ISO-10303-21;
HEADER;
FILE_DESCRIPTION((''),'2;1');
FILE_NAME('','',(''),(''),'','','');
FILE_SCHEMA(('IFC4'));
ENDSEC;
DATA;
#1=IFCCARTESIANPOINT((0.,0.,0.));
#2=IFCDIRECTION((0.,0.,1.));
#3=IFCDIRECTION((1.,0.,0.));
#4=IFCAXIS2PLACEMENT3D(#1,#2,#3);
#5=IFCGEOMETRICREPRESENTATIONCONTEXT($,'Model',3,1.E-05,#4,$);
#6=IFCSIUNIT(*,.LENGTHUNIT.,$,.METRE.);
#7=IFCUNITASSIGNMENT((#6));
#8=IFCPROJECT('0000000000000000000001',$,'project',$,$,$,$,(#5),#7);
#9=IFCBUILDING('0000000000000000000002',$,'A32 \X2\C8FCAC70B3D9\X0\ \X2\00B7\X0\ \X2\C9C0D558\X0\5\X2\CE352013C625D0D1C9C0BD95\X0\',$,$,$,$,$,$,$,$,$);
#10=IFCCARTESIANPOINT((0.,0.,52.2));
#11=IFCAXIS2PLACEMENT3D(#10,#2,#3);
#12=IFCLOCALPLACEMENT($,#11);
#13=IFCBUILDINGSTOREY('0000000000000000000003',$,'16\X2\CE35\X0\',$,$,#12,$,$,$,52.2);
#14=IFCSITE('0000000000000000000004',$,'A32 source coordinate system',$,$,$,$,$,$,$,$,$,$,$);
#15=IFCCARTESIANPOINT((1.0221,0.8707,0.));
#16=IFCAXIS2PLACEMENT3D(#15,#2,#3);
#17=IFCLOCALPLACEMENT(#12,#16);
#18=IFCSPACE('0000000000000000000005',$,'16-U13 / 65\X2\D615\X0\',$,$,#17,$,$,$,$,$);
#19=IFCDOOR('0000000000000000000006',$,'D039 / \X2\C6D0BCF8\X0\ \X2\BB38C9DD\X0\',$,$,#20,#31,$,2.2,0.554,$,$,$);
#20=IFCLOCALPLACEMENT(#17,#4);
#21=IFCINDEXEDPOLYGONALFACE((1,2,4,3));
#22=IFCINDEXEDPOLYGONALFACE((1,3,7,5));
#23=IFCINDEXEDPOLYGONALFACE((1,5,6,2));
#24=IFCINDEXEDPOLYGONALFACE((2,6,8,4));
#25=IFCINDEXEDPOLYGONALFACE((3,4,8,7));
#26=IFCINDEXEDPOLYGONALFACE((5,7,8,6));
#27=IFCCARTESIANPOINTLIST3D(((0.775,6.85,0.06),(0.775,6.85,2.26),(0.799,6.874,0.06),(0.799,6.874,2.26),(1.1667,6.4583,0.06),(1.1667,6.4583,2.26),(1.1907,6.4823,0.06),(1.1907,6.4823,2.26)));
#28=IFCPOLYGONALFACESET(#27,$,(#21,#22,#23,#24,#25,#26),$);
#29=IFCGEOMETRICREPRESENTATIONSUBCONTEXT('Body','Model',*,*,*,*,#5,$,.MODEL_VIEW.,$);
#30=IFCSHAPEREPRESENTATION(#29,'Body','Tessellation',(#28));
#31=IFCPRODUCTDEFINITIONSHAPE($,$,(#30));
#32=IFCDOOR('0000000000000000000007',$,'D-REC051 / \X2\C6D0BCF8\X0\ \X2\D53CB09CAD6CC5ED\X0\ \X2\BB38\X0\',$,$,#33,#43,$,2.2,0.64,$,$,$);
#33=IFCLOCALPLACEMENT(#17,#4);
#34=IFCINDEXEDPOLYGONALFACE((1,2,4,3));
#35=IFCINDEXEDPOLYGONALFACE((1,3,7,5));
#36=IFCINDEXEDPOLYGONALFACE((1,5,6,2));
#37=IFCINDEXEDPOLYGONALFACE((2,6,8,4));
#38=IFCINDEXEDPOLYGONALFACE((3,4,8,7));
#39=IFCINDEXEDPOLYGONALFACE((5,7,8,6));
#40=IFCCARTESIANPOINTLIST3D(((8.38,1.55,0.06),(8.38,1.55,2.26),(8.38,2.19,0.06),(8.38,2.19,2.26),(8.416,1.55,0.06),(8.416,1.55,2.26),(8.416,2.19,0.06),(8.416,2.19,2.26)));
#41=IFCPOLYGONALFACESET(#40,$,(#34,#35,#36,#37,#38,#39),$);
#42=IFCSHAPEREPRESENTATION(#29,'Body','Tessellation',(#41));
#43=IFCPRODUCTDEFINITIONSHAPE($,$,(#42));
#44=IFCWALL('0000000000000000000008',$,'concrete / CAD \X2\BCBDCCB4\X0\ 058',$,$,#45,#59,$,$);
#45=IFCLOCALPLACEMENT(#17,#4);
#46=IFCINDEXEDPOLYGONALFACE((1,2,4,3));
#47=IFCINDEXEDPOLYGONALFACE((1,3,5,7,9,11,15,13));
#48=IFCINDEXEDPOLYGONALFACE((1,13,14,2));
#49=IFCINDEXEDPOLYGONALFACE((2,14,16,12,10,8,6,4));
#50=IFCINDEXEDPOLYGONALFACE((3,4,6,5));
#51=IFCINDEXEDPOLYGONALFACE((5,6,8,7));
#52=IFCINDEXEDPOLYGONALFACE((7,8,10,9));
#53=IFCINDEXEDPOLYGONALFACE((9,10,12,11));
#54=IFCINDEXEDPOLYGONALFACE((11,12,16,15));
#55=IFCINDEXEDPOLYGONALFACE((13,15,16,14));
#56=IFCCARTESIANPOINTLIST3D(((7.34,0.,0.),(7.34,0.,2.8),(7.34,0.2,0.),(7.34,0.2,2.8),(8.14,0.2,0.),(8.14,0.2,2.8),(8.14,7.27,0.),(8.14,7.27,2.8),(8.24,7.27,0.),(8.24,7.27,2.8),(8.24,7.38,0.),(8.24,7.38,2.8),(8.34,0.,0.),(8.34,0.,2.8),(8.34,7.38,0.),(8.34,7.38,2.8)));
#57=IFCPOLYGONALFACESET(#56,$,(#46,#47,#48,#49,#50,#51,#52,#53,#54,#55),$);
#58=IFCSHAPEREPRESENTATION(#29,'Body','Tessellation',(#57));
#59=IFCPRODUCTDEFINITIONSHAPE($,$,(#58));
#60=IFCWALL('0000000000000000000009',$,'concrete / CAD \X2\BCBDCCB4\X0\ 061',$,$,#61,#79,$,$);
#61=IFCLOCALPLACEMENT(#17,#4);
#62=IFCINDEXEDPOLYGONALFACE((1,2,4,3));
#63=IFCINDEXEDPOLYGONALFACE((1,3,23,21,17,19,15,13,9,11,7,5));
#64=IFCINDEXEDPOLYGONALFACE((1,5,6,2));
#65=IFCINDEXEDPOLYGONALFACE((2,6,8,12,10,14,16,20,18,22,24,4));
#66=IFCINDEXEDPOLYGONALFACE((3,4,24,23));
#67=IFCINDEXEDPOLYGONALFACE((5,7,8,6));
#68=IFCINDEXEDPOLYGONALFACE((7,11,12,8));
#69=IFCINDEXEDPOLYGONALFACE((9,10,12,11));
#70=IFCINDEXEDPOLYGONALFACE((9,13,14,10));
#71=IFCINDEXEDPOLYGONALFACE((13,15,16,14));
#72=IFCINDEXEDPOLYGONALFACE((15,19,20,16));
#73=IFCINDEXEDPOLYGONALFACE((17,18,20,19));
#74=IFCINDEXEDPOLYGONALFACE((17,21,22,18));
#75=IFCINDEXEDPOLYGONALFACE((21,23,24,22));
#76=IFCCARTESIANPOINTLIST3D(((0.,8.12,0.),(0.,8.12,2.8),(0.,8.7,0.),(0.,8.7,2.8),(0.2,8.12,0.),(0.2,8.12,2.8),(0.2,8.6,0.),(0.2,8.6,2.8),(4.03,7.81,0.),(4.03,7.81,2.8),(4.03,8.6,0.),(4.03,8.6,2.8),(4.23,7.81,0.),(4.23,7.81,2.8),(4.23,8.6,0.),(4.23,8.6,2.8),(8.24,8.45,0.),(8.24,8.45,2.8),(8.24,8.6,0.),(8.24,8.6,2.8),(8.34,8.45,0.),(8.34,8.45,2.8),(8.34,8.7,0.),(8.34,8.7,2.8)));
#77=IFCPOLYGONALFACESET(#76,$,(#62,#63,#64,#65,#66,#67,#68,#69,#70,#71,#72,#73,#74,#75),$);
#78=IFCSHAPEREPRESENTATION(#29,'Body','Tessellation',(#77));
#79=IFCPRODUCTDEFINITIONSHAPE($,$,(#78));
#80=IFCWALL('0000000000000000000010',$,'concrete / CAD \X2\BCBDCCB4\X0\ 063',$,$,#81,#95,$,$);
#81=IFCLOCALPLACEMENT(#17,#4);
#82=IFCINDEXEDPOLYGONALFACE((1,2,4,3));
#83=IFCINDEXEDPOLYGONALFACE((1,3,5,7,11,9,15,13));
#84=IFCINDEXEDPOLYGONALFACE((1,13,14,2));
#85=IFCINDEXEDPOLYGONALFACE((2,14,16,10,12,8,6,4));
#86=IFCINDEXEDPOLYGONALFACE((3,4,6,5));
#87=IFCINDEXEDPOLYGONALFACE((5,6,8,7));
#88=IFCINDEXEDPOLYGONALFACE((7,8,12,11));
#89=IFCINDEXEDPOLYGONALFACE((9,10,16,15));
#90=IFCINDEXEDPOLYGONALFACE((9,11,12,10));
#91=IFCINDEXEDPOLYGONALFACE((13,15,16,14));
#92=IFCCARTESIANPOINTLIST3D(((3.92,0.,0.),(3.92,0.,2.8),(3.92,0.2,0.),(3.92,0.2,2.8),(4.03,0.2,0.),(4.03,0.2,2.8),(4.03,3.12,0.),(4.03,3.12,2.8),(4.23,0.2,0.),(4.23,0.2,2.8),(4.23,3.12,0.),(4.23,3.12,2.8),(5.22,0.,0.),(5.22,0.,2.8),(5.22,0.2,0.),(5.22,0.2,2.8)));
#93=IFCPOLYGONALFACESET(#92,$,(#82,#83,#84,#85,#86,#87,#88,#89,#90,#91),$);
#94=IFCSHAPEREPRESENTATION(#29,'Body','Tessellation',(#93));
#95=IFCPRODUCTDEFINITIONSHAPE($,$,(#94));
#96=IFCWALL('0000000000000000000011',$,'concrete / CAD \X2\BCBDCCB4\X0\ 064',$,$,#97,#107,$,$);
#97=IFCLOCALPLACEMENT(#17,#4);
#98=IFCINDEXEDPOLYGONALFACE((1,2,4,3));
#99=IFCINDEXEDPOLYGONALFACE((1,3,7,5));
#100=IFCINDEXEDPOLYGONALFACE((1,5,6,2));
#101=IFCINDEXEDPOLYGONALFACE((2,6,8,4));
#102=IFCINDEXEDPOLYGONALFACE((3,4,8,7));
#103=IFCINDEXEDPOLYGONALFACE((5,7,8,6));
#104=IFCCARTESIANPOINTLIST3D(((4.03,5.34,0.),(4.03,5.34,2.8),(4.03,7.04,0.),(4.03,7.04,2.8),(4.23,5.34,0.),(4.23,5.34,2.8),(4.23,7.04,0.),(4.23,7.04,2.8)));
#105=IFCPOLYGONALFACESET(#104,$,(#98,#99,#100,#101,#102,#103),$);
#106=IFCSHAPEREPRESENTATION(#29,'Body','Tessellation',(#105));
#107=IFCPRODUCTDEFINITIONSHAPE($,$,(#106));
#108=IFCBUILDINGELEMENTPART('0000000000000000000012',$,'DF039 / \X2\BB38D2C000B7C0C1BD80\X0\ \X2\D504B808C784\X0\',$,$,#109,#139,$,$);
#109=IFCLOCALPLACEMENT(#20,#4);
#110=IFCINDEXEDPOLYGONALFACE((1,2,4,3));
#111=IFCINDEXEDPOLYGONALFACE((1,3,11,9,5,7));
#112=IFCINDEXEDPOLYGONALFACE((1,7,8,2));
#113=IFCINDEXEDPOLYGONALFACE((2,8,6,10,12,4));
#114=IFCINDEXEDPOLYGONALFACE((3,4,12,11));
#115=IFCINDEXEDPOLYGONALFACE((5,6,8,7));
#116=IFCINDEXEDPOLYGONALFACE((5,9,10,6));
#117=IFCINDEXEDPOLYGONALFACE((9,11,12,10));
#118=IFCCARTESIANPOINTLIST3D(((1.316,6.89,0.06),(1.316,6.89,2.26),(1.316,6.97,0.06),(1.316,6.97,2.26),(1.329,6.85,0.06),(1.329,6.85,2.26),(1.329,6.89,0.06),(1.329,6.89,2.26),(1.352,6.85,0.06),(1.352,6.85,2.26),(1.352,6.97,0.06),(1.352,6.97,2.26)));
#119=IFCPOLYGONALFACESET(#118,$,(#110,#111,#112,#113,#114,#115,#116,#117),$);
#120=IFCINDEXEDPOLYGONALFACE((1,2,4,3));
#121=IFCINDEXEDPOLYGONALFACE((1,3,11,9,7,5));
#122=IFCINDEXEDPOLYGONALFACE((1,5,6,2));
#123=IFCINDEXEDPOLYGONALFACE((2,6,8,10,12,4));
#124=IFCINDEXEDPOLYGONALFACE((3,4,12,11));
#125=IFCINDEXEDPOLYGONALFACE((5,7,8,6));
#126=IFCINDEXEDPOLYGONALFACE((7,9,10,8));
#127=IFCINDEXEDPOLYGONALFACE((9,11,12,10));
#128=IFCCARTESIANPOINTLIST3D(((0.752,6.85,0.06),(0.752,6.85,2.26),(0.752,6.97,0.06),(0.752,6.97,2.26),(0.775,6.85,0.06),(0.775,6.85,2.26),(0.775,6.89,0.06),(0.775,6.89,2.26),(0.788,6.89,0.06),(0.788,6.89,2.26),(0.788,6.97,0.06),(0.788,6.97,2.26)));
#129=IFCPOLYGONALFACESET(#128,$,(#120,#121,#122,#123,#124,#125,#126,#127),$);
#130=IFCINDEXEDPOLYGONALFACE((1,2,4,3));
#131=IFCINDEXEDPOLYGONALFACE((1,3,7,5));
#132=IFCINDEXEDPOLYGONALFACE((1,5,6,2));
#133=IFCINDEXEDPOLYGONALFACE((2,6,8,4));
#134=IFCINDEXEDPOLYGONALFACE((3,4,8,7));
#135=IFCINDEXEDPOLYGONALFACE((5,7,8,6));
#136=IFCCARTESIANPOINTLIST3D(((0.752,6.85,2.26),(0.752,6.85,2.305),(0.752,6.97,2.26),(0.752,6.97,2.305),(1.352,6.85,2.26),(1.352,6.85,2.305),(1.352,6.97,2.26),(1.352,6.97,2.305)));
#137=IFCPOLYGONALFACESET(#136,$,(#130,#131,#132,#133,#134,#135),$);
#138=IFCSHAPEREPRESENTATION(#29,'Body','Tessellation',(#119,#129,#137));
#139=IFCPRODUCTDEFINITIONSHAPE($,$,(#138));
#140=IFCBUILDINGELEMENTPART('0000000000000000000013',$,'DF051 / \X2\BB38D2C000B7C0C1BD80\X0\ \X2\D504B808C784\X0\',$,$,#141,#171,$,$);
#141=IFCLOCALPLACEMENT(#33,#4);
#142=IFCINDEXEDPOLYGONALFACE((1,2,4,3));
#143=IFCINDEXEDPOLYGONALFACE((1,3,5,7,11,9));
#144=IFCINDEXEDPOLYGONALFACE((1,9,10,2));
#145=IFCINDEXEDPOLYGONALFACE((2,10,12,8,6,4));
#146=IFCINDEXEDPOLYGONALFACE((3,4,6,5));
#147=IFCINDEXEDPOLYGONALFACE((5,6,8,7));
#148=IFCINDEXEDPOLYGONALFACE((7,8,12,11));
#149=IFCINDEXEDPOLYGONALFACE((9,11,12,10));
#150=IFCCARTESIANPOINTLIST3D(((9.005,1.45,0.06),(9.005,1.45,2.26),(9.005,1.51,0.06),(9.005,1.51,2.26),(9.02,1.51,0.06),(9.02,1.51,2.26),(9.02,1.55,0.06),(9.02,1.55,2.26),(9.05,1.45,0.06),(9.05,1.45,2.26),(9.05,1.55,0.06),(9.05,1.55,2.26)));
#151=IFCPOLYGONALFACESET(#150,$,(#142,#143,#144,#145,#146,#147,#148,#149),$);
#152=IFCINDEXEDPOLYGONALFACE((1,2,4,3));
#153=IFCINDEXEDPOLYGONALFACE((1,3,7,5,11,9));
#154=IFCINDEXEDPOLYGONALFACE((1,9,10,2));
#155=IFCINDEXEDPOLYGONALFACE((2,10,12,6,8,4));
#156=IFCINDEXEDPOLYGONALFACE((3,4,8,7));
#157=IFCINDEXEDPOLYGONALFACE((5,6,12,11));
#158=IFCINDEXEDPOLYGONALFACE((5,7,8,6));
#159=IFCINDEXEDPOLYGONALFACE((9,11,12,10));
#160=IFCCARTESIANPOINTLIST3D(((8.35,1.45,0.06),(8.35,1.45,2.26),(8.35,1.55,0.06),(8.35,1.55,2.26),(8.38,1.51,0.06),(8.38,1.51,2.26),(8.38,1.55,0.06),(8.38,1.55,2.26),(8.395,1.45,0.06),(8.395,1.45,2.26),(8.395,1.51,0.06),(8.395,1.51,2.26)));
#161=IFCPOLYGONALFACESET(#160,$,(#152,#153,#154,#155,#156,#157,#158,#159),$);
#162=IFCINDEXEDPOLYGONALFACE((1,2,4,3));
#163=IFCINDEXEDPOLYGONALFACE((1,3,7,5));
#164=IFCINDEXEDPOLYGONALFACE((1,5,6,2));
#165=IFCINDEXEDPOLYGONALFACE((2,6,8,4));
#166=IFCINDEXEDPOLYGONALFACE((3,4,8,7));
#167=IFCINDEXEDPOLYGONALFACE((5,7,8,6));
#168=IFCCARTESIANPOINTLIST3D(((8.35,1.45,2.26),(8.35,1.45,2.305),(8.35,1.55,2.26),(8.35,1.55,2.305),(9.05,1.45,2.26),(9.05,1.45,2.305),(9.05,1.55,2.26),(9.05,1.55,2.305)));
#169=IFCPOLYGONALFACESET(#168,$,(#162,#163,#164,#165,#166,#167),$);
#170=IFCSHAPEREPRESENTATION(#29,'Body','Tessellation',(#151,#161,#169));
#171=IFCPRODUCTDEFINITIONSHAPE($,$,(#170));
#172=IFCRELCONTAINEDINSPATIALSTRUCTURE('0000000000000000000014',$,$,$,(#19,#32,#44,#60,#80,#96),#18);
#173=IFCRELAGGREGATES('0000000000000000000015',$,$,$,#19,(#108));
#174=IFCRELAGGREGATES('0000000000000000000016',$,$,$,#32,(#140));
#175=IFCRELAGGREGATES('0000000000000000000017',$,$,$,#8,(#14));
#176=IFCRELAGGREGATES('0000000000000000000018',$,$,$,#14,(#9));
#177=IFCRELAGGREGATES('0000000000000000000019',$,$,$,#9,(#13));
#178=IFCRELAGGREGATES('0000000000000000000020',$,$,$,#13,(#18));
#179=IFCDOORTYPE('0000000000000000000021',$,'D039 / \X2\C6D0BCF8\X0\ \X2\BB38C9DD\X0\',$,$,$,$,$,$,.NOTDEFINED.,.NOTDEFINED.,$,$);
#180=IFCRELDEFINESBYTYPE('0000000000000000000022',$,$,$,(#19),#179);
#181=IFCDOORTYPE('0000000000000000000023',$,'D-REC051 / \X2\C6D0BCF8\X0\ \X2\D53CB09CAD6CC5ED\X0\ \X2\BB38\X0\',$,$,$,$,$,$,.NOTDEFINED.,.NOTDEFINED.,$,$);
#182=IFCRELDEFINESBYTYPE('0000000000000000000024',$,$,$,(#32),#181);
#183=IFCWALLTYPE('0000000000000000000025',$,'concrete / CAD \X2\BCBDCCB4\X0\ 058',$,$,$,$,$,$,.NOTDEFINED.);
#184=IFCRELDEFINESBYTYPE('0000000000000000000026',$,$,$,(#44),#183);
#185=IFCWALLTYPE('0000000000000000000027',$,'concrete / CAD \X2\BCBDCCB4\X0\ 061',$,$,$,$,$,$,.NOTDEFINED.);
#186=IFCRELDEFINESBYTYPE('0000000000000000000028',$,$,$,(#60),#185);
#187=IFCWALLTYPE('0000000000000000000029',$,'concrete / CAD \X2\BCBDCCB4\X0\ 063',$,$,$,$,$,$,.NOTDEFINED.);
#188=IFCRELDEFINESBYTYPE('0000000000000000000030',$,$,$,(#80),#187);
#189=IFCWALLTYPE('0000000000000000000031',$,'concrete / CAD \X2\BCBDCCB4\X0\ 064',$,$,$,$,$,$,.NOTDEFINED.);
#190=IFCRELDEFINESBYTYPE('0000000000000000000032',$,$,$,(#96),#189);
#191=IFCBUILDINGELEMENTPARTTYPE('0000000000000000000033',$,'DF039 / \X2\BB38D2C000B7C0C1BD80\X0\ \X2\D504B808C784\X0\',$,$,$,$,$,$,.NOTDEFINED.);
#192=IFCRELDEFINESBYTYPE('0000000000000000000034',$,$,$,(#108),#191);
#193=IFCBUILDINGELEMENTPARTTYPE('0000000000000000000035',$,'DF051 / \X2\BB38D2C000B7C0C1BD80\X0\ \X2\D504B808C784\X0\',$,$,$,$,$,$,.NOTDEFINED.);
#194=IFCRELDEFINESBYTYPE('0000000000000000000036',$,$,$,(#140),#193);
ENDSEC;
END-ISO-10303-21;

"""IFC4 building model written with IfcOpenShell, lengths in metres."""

from ifc_helpers import new_model, si_unit, frame, origin, origin_with_axes, place, context, subcontext, project, spatial, polyline, outline, extrude, source, transform, mapped, type_object, type_shapes, element, aggregate, save


model = new_model("IFC4")

# Units and contexts
model_context = context("Model", 3, precision=1e-05, world=origin_with_axes())
body_context = subcontext(model_context, "Body", "Model", "MODEL_VIEW")
ifc_project = project(units=[si_unit("LENGTHUNIT", "METRE")], contexts=[model_context])

# Site, building, storey, space
storey_placement = place(None, frame((0.0, 0.0, 52.2), z_axis=(0.0, 0.0, 1.0), x_axis=(1.0, 0.0, 0.0)))
space_placement = place(storey_placement, frame((1.0221, 0.8707, 0.0), z_axis=(0.0, 0.0, 1.0), x_axis=(1.0, 0.0, 0.0)))
site = spatial("IfcSite", under=ifc_project, Name="A32 source coordinate system")
building = spatial("IfcBuilding", under=site, Name="A32 주거동 · 지하5층–옥탑지붕")
storey = spatial("IfcBuildingStorey", under=building, at=storey_placement, Name="16층", Elevation=52.2)
space = spatial("IfcSpace", under=storey, at=space_placement, Name="16-U13 / 65형")

# Doors
door_type_1 = type_object("IfcDoorType", Name="D039 / 원본 문짝", OperationType="NOTDEFINED", PredefinedType="NOTDEFINED")
shared_shape_1 = source(origin(), body_context, "Body", "SweptSolid", [
    extrude(outline(polyline([(1.1907, 6.4823), (1.1667, 6.4583), (0.775, 6.85), (0.799, 6.874), (1.1907, 6.4823)])), frame((0.0, 0.0, 0.06)), (0.0, 0.0, 1.0), 2.2),
])
type_shapes(door_type_1, [shared_shape_1])
door_1_placement = place(space_placement, origin_with_axes())
door_1 = element("IfcDoor", 1, at=door_1_placement, inside=space, type_object=door_type_1, Name="D039 / 원본 문짝", OverallHeight=2.2, OverallWidth=0.554, context=body_context, shape_type="MappedRepresentation", body=[
    mapped(shared_shape_1, transform((0.0, 0.0, 0.0), scale=1.0)),
])
door_type_2 = type_object("IfcDoorType", Name="D-REC051 / 원본 피난구역 문", OperationType="NOTDEFINED", PredefinedType="NOTDEFINED")
shared_shape_2 = source(origin(), body_context, "Body", "SweptSolid", [
    extrude(outline(polyline([(8.416, 2.19), (8.416, 1.55), (8.38, 1.55), (8.38, 2.19), (8.416, 2.19)])), frame((0.0, 0.0, 0.06)), (0.0, 0.0, 1.0), 2.2),
])
type_shapes(door_type_2, [shared_shape_2])
door_2_placement = place(space_placement, origin_with_axes())
door_2 = element("IfcDoor", 2, at=door_2_placement, inside=space, type_object=door_type_2, Name="D-REC051 / 원본 피난구역 문", OverallHeight=2.2, OverallWidth=0.64, context=body_context, shape_type="MappedRepresentation", body=[
    mapped(shared_shape_2, transform((0.0, 0.0, 0.0), scale=1.0)),
])

# Walls
wall_type_1 = type_object("IfcWallType", Name="concrete / CAD 벽체 058", PredefinedType="NOTDEFINED")
shared_shape_3 = source(origin(), body_context, "Body", "SweptSolid", [
    extrude(outline(polyline([(8.34, 0.0), (7.34, 0.0), (7.34, 0.2), (8.14, 0.2), (8.14, 7.27), (8.24, 7.27), (8.24, 7.38), (8.34, 7.38), (8.34, 0.0)])), origin(), (0.0, 0.0, 1.0), 2.8),
])
type_shapes(wall_type_1, [shared_shape_3])
wall_1_placement = place(space_placement, origin_with_axes())
element("IfcWall", 3, at=wall_1_placement, inside=space, type_object=wall_type_1, Name="concrete / CAD 벽체 058", context=body_context, shape_type="MappedRepresentation", body=[
    mapped(shared_shape_3, transform((0.0, 0.0, 0.0), scale=1.0)),
])
wall_type_2 = type_object("IfcWallType", Name="concrete / CAD 벽체 061", PredefinedType="NOTDEFINED")
shared_shape_4 = source(origin(), body_context, "Body", "SweptSolid", [
    extrude(outline(polyline([(0.2, 8.6), (0.2, 8.12), (0.0, 8.12), (0.0, 8.7), (8.34, 8.7), (8.34, 8.45), (8.24, 8.45), (8.24, 8.6), (4.23, 8.6), (4.23, 7.81), (4.03, 7.81), (4.03, 8.6), (0.2, 8.6)])), origin(), (0.0, 0.0, 1.0), 2.8),
])
type_shapes(wall_type_2, [shared_shape_4])
wall_2_placement = place(space_placement, origin_with_axes())
element("IfcWall", 4, at=wall_2_placement, inside=space, type_object=wall_type_2, Name="concrete / CAD 벽체 061", context=body_context, shape_type="MappedRepresentation", body=[
    mapped(shared_shape_4, transform((0.0, 0.0, 0.0), scale=1.0)),
])
wall_type_3 = type_object("IfcWallType", Name="concrete / CAD 벽체 063", PredefinedType="NOTDEFINED")
shared_shape_5 = source(origin(), body_context, "Body", "SweptSolid", [
    extrude(outline(polyline([(5.22, 0.0), (3.92, 0.0), (3.92, 0.2), (4.03, 0.2), (4.03, 3.12), (4.23, 3.12), (4.23, 0.2), (5.22, 0.2), (5.22, 0.0)])), origin(), (0.0, 0.0, 1.0), 2.8),
])
type_shapes(wall_type_3, [shared_shape_5])
wall_3_placement = place(space_placement, origin_with_axes())
element("IfcWall", 5, at=wall_3_placement, inside=space, type_object=wall_type_3, Name="concrete / CAD 벽체 063", context=body_context, shape_type="MappedRepresentation", body=[
    mapped(shared_shape_5, transform((0.0, 0.0, 0.0), scale=1.0)),
])
wall_type_4 = type_object("IfcWallType", Name="concrete / CAD 벽체 064", PredefinedType="NOTDEFINED")
shared_shape_6 = source(origin(), body_context, "Body", "SweptSolid", [
    extrude(outline(polyline([(4.03, 7.04), (4.23, 7.04), (4.23, 5.34), (4.03, 5.34), (4.03, 7.04)])), origin(), (0.0, 0.0, 1.0), 2.8),
])
type_shapes(wall_type_4, [shared_shape_6])
wall_4_placement = place(space_placement, origin_with_axes())
element("IfcWall", 6, at=wall_4_placement, inside=space, type_object=wall_type_4, Name="concrete / CAD 벽체 064", context=body_context, shape_type="MappedRepresentation", body=[
    mapped(shared_shape_6, transform((0.0, 0.0, 0.0), scale=1.0)),
])

# Building element parts
building_element_part_type_1 = type_object("IfcBuildingElementPartType", Name="DF039 / 문틀·상부 프레임", PredefinedType="NOTDEFINED")
shared_shape_7 = source(origin(), body_context, "Body", "SweptSolid", [
    extrude(outline(polyline([(1.352, 6.85), (1.329, 6.85), (1.329, 6.89), (1.316, 6.89), (1.316, 6.97), (1.352, 6.97), (1.352, 6.85)])), frame((0.0, 0.0, 0.06)), (0.0, 0.0, 1.0), 2.2),
    extrude(outline(polyline([(0.788, 6.97), (0.788, 6.89), (0.775, 6.89), (0.775, 6.85), (0.752, 6.85), (0.752, 6.97), (0.788, 6.97)])), frame((0.0, 0.0, 0.06)), (0.0, 0.0, 1.0), 2.2),
    extrude(outline(polyline([(0.752, 6.85), (0.752, 6.97), (1.352, 6.97), (1.352, 6.85), (0.752, 6.85)])), frame((0.0, 0.0, 2.26)), (0.0, 0.0, 1.0), 0.045),
])
type_shapes(building_element_part_type_1, [shared_shape_7])
building_element_part_1_placement = place(door_1_placement, origin_with_axes())
building_element_part_1 = element("IfcBuildingElementPart", 7, at=building_element_part_1_placement, type_object=building_element_part_type_1, Name="DF039 / 문틀·상부 프레임", context=body_context, shape_type="MappedRepresentation", body=[
    mapped(shared_shape_7, transform((0.0, 0.0, 0.0), scale=1.0)),
])
aggregate(door_1, [building_element_part_1])
building_element_part_type_2 = type_object("IfcBuildingElementPartType", Name="DF051 / 문틀·상부 프레임", PredefinedType="NOTDEFINED")
shared_shape_8 = source(origin(), body_context, "Body", "SweptSolid", [
    extrude(outline(polyline([(9.05, 1.45), (9.005, 1.45), (9.005, 1.51), (9.02, 1.51), (9.02, 1.55), (9.05, 1.55), (9.05, 1.45)])), frame((0.0, 0.0, 0.06)), (0.0, 0.0, 1.0), 2.2),
    extrude(outline(polyline([(8.38, 1.55), (8.38, 1.51), (8.395, 1.51), (8.395, 1.45), (8.35, 1.45), (8.35, 1.55), (8.38, 1.55)])), frame((0.0, 0.0, 0.06)), (0.0, 0.0, 1.0), 2.2),
    extrude(outline(polyline([(8.35, 1.45), (8.35, 1.55), (9.05, 1.55), (9.05, 1.45), (8.35, 1.45)])), frame((0.0, 0.0, 2.26)), (0.0, 0.0, 1.0), 0.045),
])
type_shapes(building_element_part_type_2, [shared_shape_8])
building_element_part_2_placement = place(door_2_placement, origin_with_axes())
building_element_part_2 = element("IfcBuildingElementPart", 8, at=building_element_part_2_placement, type_object=building_element_part_type_2, Name="DF051 / 문틀·상부 프레임", context=body_context, shape_type="MappedRepresentation", body=[
    mapped(shared_shape_8, transform((0.0, 0.0, 0.0), scale=1.0)),
])
aggregate(door_2, [building_element_part_2])

save(model, "model.ifc")
